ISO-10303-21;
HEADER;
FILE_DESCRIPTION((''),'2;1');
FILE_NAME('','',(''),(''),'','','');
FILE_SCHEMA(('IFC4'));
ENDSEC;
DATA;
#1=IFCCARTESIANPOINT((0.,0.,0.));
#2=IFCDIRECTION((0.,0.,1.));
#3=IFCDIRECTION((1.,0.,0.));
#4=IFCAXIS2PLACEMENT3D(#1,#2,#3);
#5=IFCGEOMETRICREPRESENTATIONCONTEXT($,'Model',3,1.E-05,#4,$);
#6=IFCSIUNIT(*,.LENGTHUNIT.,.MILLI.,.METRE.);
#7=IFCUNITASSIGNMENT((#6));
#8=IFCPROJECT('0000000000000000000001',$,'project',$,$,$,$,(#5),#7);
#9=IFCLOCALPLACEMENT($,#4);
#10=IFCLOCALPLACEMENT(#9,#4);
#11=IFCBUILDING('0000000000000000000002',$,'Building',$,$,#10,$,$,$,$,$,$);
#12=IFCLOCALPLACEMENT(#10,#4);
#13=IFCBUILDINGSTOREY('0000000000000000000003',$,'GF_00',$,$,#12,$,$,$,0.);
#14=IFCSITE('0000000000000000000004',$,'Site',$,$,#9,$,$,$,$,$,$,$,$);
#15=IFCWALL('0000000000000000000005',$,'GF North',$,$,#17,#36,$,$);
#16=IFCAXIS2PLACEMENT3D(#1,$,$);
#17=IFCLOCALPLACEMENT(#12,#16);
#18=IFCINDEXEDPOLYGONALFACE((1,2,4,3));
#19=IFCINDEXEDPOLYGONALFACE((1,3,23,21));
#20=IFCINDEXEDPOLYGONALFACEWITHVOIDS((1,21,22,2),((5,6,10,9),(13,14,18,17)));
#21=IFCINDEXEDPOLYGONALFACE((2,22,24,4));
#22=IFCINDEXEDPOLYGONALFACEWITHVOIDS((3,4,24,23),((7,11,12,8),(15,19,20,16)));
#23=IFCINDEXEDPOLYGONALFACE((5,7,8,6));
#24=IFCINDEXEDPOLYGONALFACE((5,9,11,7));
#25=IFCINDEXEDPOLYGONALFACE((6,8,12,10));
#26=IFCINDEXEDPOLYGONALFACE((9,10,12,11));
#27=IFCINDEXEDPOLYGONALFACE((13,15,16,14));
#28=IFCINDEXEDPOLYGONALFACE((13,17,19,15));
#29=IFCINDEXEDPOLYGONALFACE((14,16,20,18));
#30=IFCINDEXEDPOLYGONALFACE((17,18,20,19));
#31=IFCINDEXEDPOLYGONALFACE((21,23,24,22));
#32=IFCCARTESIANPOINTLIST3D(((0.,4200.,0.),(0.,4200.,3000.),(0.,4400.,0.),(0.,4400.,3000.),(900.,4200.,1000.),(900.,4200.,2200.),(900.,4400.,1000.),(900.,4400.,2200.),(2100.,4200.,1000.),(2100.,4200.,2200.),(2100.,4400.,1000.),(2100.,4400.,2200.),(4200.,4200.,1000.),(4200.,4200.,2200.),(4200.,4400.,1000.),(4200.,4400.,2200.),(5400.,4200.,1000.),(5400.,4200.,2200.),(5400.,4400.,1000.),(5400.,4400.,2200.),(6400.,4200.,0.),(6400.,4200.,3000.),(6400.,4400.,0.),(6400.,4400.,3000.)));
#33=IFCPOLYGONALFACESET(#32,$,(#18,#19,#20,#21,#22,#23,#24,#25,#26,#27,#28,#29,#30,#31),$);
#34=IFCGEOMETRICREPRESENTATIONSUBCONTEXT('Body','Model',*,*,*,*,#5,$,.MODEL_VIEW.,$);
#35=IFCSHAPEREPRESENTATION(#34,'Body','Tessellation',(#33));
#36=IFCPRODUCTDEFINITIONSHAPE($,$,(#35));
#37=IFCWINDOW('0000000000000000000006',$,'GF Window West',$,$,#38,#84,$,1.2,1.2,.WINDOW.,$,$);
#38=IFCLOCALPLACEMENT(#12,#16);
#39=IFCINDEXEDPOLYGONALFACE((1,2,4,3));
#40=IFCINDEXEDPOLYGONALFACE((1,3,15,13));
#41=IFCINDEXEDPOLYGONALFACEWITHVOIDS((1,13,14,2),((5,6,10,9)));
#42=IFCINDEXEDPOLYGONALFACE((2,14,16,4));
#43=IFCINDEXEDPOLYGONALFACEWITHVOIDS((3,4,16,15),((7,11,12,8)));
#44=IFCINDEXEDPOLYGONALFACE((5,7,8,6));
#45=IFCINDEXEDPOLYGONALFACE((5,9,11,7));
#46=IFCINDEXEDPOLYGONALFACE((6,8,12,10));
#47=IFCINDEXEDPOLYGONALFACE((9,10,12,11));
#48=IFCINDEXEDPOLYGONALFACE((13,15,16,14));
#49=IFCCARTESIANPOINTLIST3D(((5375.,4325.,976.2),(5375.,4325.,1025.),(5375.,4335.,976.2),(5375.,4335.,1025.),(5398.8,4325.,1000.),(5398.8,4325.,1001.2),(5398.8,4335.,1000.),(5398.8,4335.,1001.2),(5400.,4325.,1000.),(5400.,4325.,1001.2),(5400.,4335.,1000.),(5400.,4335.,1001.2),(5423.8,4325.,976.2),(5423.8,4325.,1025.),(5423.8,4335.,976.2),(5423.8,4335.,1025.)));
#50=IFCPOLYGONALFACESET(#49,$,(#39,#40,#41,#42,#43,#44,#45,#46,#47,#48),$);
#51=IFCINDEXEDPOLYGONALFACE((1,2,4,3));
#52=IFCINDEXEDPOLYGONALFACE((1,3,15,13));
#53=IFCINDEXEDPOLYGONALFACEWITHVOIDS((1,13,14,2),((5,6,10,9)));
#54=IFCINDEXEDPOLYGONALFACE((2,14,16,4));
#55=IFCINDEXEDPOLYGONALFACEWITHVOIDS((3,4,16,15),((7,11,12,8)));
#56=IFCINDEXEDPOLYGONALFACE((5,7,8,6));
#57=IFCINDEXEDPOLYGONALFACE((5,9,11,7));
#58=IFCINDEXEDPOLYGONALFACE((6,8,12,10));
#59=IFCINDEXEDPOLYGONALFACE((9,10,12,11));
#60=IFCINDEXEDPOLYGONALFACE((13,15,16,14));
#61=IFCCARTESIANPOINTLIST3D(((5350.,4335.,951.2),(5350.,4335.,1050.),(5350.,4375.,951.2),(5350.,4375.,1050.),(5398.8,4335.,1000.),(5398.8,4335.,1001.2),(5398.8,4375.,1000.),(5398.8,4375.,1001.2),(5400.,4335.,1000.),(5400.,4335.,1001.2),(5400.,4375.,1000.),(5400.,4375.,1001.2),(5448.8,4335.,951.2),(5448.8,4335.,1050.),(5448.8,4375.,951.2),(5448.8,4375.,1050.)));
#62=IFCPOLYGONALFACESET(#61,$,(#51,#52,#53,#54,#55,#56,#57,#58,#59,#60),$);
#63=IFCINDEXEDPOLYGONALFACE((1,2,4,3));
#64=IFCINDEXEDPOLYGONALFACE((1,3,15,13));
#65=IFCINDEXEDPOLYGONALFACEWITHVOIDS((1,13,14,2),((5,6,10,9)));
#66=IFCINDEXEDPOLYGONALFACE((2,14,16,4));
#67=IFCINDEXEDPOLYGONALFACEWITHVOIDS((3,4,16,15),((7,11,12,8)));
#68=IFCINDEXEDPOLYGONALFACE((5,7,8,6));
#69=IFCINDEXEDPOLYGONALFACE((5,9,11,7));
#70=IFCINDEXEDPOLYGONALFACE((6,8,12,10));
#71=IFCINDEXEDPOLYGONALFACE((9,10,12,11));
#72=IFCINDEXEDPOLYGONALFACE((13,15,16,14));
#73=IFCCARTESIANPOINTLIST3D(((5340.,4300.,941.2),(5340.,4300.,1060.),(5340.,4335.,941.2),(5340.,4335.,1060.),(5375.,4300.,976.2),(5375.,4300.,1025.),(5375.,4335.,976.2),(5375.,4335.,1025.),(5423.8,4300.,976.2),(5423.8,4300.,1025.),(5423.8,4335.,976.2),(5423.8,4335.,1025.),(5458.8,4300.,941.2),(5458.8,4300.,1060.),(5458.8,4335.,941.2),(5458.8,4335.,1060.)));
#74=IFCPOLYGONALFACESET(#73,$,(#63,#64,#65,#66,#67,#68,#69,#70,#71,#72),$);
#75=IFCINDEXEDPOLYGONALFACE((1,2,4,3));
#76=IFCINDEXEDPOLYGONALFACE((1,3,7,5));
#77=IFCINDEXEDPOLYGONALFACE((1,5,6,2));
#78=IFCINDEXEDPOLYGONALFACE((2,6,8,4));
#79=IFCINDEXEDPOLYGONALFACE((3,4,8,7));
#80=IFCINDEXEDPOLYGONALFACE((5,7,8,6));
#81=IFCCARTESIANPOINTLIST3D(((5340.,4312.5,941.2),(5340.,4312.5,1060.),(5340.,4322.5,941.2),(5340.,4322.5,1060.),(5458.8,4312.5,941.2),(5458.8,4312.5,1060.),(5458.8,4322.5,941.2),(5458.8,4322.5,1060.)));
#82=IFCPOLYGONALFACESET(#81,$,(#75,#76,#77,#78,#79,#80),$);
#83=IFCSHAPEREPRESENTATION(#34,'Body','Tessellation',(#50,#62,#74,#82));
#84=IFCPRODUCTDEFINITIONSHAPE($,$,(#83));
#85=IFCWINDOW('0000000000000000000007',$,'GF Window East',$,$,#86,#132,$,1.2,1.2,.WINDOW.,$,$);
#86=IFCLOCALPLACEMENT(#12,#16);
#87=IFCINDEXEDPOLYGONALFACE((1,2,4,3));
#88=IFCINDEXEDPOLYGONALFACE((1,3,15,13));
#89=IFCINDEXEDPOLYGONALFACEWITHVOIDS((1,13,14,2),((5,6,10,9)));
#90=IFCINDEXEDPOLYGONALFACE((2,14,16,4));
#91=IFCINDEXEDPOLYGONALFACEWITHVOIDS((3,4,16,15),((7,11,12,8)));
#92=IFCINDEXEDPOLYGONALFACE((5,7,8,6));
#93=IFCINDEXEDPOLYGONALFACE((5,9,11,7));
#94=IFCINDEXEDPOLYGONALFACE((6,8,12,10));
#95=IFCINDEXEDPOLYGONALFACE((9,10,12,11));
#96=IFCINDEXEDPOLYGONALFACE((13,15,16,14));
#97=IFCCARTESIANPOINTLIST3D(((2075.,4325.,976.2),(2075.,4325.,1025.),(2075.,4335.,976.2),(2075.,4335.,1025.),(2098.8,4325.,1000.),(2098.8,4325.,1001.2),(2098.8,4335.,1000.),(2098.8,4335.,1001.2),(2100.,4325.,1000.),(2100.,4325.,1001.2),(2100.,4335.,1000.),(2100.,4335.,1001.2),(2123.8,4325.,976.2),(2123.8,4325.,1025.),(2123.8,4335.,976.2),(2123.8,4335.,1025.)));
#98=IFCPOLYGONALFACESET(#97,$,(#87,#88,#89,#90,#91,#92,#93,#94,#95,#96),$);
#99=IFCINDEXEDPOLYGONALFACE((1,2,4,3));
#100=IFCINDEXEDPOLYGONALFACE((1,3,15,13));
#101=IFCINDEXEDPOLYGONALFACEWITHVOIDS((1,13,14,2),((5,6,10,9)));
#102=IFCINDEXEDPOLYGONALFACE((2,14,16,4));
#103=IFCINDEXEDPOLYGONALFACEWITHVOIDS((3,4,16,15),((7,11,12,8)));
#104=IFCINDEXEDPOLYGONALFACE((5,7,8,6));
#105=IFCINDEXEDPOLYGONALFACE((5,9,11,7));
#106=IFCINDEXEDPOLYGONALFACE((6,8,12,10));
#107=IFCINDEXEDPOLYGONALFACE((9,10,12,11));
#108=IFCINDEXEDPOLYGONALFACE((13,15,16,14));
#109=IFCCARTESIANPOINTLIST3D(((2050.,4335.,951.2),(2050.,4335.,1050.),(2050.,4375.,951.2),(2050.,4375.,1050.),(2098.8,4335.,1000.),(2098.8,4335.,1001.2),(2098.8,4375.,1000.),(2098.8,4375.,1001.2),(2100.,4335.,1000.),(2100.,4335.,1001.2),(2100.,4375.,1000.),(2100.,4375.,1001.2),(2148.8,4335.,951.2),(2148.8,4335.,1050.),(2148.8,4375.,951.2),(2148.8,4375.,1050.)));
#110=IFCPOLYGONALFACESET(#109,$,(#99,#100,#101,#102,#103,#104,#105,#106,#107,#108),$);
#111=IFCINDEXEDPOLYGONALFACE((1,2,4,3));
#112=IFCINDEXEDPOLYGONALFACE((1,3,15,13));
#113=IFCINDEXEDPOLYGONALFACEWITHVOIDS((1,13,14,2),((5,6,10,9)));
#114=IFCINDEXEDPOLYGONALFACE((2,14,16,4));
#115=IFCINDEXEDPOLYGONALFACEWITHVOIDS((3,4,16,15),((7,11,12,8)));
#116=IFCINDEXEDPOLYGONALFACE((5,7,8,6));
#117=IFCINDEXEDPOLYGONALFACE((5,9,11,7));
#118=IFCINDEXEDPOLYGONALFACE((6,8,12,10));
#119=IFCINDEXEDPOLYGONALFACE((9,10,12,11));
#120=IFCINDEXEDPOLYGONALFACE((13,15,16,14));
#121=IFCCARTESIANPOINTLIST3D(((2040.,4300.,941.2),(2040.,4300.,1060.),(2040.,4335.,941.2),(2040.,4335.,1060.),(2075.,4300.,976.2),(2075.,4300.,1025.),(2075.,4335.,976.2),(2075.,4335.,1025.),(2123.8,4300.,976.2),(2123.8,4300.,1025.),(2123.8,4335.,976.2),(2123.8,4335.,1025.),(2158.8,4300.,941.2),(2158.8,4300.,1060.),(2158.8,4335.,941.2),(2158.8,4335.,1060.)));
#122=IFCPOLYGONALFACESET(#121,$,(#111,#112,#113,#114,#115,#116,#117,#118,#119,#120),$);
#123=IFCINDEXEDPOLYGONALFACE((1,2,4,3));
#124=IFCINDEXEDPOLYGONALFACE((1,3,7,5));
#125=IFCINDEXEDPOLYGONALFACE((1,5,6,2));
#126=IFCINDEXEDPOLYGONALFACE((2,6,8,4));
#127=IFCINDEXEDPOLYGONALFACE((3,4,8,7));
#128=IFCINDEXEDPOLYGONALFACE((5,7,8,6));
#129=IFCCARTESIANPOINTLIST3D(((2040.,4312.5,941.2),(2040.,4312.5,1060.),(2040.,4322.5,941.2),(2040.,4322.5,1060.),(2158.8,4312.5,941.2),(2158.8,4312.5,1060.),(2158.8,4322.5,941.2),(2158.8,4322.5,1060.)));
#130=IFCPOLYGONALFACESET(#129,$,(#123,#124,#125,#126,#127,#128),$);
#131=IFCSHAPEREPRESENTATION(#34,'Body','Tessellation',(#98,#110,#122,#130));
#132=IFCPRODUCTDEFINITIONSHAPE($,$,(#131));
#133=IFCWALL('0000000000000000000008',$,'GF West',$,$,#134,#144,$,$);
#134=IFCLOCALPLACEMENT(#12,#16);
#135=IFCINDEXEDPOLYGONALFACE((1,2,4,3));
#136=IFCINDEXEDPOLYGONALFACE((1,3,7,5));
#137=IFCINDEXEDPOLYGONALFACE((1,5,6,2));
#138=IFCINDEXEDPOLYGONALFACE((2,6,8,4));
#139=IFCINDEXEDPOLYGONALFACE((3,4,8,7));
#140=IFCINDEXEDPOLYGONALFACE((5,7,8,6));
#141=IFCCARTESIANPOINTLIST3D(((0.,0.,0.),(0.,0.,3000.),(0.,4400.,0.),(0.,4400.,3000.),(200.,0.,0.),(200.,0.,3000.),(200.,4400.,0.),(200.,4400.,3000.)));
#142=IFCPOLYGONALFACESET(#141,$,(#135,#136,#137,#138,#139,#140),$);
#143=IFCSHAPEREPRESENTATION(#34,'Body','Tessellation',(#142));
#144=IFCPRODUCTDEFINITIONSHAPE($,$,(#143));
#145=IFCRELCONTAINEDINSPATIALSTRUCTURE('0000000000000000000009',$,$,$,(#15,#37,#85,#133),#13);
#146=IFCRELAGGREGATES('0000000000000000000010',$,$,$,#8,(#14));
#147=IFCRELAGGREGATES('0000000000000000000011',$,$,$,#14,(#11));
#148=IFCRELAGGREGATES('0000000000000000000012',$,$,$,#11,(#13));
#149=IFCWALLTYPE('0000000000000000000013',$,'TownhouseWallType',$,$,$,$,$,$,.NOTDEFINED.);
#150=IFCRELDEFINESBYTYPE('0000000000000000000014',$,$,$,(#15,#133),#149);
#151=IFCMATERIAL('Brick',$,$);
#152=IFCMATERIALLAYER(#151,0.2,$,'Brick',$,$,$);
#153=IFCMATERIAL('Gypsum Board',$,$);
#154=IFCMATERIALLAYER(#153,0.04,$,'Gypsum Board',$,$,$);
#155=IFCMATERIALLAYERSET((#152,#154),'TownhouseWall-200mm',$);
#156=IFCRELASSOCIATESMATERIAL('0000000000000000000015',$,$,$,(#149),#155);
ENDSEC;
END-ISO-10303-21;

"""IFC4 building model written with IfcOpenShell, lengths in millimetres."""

from ifc_helpers import new_model, si_unit, frame, origin_with_axes, place, context, subcontext, project, spatial, line, indexed_curve, outline, extrude, material, layer, layer_set, type_object, element, fill, save


model = new_model("IFC4")

# Units and contexts
model_context = context("Model", 3, precision=1e-05, world=origin_with_axes())
body_context = subcontext(model_context, "Body", "Model", "MODEL_VIEW")
ifc_project = project(units=[si_unit("LENGTHUNIT", "METRE", prefix="MILLI")], contexts=[model_context])

# Site, building, storey
site_placement = place(None, origin_with_axes())
site = spatial("IfcSite", under=ifc_project, at=site_placement, Name="Site")
building_placement = place(site_placement, origin_with_axes())
building = spatial("IfcBuilding", under=site, at=building_placement, Name="Building")
storey_placement = place(building_placement, origin_with_axes())
storey = spatial("IfcBuildingStorey", under=building, at=storey_placement, Name="GF_00", Elevation=0.0)

# Shared definitions
ifc_material_1 = material(Name="Brick")
ifc_layer_1 = layer(ifc_material_1, 0.2, Name="Brick")
ifc_material_2 = material(Name="Gypsum Board")
ifc_layer_2 = layer(ifc_material_2, 0.04, Name="Gypsum Board")
ifc_layer_set_1 = layer_set([ifc_layer_1, ifc_layer_2], Name="TownhouseWall-200mm")
wall_type = type_object("IfcWallType", Name="TownhouseWallType", PredefinedType="NOTDEFINED", material=ifc_layer_set_1)

# Wall, openings, windows
wall_1_placement = place(storey_placement, frame((6400.0, 4400.0, 0.0), z_axis=(0.0, 0.0, 1.0), x_axis=(-1.0, 0.0, 0.0)))
wall_1 = element("IfcWall", 1, at=wall_1_placement, inside=storey, type_object=wall_type, Name="GF North", context=body_context, shape_type="SweptSolid", body=[
    extrude(outline(indexed_curve([(0.0, 0.0), (0.0, 200.0), (6400.0, 200.0), (6400.0, 0.0), (0.0, 0.0)], self_intersect=False)), origin_with_axes(), (0.0, 0.0, 1.0), 3000.0),
])
opening_1_placement = place(wall_1_placement, frame((1000.0, -25.0, 1000.0), z_axis=(0.0, 0.0, 1.0), x_axis=(1.0, 0.0, 0.0)))
opening_1 = element("IfcOpeningElement", 2, at=opening_1_placement, cuts=wall_1, context=body_context, shape_type="SweptSolid", body=[
    extrude(outline(indexed_curve([(0.0, 0.0), (0.0, 250.0), (1200.0, 250.0), (1200.0, 0.0), (0.0, 0.0)], self_intersect=False)), origin_with_axes(), (0.0, 0.0, 1.0), 1200.0),
])
opening_2_placement = place(wall_1_placement, frame((4300.0, -25.0, 1000.0), z_axis=(0.0, 0.0, 1.0), x_axis=(1.0, 0.0, 0.0)))
opening_2 = element("IfcOpeningElement", 3, at=opening_2_placement, cuts=wall_1, context=body_context, shape_type="SweptSolid", body=[
    extrude(outline(indexed_curve([(0.0, 0.0), (0.0, 250.0), (1200.0, 250.0), (1200.0, 0.0), (0.0, 0.0)], self_intersect=False)), origin_with_axes(), (0.0, 0.0, 1.0), 1200.0),
])
window_1_placement = place(storey_placement, frame((5400.0, 4425.0, 1000.0), z_axis=(0.0, 0.0, 1.0), x_axis=(-1.0, 0.0, 0.0)))
window_1 = element("IfcWindow", 4, at=window_1_placement, inside=storey, Name="GF Window West", OverallHeight=1.2, OverallWidth=1.2, PredefinedType="WINDOW", context=body_context, shape_type="SweptSolid", body=[
    extrude(outline(indexed_curve([(0.0, 0.0), (1.2, 0.0), (1.2, 1.2), (0.0, 1.2)], segments=[line(1, 2, 3, 4, 1)]), holes=[indexed_curve([(25.0, 25.0), (-23.8, 25.0), (-23.8, -23.8), (25.0, -23.8)], segments=[line(1, 2, 3, 4, 1)])]), frame((0.0, 90.0, 0.0), z_axis=(0.0, -1.0, 0.0), x_axis=(1.0, 0.0, 0.0)), (0.0, 0.0, -1.0), 10.0),
    extrude(outline(indexed_curve([(0.0, 0.0), (1.2, 0.0), (1.2, 1.2), (0.0, 1.2)], segments=[line(1, 2, 3, 4, 1)]), holes=[indexed_curve([(50.0, 50.0), (-48.8, 50.0), (-48.8, -48.8), (50.0, -48.8)], segments=[line(1, 2, 3, 4, 1)])]), frame((0.0, 50.0, 0.0), z_axis=(0.0, -1.0, 0.0), x_axis=(1.0, 0.0, 0.0)), (0.0, 0.0, -1.0), 40.0),
    extrude(outline(indexed_curve([(0.0, 0.0), (-48.8, 0.0), (-48.8, -48.8), (0.0, -48.8)], segments=[line(1, 2, 3, 4, 1)]), holes=[indexed_curve([(35.0, 35.0), (-83.8, 35.0), (-83.8, -83.8), (35.0, -83.8)], segments=[line(1, 2, 3, 4, 1)])]), frame((25.0, 90.0, 25.0), z_axis=(0.0, -1.0, 0.0), x_axis=(1.0, 0.0, 0.0)), (0.0, 0.0, -1.0), 35.0),
    extrude(outline(indexed_curve([(35.0, 35.0), (-83.8, 35.0), (-83.8, -83.8), (35.0, -83.8)], segments=[line(1, 2, 3, 4, 1)])), frame((25.0, 102.5, 25.0), z_axis=(0.0, -1.0, 0.0), x_axis=(1.0, 0.0, 0.0)), (0.0, 0.0, -1.0), 10.0),
])
fill(opening_1, window_1)
window_2_placement = place(storey_placement, frame((2100.0, 4425.0, 1000.0), z_axis=(0.0, 0.0, 1.0), x_axis=(-1.0, 0.0, 0.0)))
window_2 = element("IfcWindow", 5, at=window_2_placement, inside=storey, Name="GF Window East", OverallHeight=1.2, OverallWidth=1.2, PredefinedType="WINDOW", context=body_context, shape_type="SweptSolid", body=[
    extrude(outline(indexed_curve([(0.0, 0.0), (1.2, 0.0), (1.2, 1.2), (0.0, 1.2)], segments=[line(1, 2, 3, 4, 1)]), holes=[indexed_curve([(25.0, 25.0), (-23.8, 25.0), (-23.8, -23.8), (25.0, -23.8)], segments=[line(1, 2, 3, 4, 1)])]), frame((0.0, 90.0, 0.0), z_axis=(0.0, -1.0, 0.0), x_axis=(1.0, 0.0, 0.0)), (0.0, 0.0, -1.0), 10.0),
    extrude(outline(indexed_curve([(0.0, 0.0), (1.2, 0.0), (1.2, 1.2), (0.0, 1.2)], segments=[line(1, 2, 3, 4, 1)]), holes=[indexed_curve([(50.0, 50.0), (-48.8, 50.0), (-48.8, -48.8), (50.0, -48.8)], segments=[line(1, 2, 3, 4, 1)])]), frame((0.0, 50.0, 0.0), z_axis=(0.0, -1.0, 0.0), x_axis=(1.0, 0.0, 0.0)), (0.0, 0.0, -1.0), 40.0),
    extrude(outline(indexed_curve([(0.0, 0.0), (-48.8, 0.0), (-48.8, -48.8), (0.0, -48.8)], segments=[line(1, 2, 3, 4, 1)]), holes=[indexed_curve([(35.0, 35.0), (-83.8, 35.0), (-83.8, -83.8), (35.0, -83.8)], segments=[line(1, 2, 3, 4, 1)])]), frame((25.0, 90.0, 25.0), z_axis=(0.0, -1.0, 0.0), x_axis=(1.0, 0.0, 0.0)), (0.0, 0.0, -1.0), 35.0),
    extrude(outline(indexed_curve([(35.0, 35.0), (-83.8, 35.0), (-83.8, -83.8), (35.0, -83.8)], segments=[line(1, 2, 3, 4, 1)])), frame((25.0, 102.5, 25.0), z_axis=(0.0, -1.0, 0.0), x_axis=(1.0, 0.0, 0.0)), (0.0, 0.0, -1.0), 10.0),
])
fill(opening_2, window_2)

# Wall
wall_2_placement = place(storey_placement, frame((0.0, 4400.0, 0.0), z_axis=(0.0, 0.0, 1.0), x_axis=(0.0, -1.0, 0.0)))
element("IfcWall", 6, at=wall_2_placement, inside=storey, type_object=wall_type, Name="GF West", context=body_context, shape_type="SweptSolid", body=[
    extrude(outline(indexed_curve([(0.0, 0.0), (0.0, 200.0), (4400.0, 200.0), (4400.0, 0.0), (0.0, 0.0)], self_intersect=False)), origin_with_axes(), (0.0, 0.0, 1.0), 3000.0),
])

save(model, "model.ifc")
